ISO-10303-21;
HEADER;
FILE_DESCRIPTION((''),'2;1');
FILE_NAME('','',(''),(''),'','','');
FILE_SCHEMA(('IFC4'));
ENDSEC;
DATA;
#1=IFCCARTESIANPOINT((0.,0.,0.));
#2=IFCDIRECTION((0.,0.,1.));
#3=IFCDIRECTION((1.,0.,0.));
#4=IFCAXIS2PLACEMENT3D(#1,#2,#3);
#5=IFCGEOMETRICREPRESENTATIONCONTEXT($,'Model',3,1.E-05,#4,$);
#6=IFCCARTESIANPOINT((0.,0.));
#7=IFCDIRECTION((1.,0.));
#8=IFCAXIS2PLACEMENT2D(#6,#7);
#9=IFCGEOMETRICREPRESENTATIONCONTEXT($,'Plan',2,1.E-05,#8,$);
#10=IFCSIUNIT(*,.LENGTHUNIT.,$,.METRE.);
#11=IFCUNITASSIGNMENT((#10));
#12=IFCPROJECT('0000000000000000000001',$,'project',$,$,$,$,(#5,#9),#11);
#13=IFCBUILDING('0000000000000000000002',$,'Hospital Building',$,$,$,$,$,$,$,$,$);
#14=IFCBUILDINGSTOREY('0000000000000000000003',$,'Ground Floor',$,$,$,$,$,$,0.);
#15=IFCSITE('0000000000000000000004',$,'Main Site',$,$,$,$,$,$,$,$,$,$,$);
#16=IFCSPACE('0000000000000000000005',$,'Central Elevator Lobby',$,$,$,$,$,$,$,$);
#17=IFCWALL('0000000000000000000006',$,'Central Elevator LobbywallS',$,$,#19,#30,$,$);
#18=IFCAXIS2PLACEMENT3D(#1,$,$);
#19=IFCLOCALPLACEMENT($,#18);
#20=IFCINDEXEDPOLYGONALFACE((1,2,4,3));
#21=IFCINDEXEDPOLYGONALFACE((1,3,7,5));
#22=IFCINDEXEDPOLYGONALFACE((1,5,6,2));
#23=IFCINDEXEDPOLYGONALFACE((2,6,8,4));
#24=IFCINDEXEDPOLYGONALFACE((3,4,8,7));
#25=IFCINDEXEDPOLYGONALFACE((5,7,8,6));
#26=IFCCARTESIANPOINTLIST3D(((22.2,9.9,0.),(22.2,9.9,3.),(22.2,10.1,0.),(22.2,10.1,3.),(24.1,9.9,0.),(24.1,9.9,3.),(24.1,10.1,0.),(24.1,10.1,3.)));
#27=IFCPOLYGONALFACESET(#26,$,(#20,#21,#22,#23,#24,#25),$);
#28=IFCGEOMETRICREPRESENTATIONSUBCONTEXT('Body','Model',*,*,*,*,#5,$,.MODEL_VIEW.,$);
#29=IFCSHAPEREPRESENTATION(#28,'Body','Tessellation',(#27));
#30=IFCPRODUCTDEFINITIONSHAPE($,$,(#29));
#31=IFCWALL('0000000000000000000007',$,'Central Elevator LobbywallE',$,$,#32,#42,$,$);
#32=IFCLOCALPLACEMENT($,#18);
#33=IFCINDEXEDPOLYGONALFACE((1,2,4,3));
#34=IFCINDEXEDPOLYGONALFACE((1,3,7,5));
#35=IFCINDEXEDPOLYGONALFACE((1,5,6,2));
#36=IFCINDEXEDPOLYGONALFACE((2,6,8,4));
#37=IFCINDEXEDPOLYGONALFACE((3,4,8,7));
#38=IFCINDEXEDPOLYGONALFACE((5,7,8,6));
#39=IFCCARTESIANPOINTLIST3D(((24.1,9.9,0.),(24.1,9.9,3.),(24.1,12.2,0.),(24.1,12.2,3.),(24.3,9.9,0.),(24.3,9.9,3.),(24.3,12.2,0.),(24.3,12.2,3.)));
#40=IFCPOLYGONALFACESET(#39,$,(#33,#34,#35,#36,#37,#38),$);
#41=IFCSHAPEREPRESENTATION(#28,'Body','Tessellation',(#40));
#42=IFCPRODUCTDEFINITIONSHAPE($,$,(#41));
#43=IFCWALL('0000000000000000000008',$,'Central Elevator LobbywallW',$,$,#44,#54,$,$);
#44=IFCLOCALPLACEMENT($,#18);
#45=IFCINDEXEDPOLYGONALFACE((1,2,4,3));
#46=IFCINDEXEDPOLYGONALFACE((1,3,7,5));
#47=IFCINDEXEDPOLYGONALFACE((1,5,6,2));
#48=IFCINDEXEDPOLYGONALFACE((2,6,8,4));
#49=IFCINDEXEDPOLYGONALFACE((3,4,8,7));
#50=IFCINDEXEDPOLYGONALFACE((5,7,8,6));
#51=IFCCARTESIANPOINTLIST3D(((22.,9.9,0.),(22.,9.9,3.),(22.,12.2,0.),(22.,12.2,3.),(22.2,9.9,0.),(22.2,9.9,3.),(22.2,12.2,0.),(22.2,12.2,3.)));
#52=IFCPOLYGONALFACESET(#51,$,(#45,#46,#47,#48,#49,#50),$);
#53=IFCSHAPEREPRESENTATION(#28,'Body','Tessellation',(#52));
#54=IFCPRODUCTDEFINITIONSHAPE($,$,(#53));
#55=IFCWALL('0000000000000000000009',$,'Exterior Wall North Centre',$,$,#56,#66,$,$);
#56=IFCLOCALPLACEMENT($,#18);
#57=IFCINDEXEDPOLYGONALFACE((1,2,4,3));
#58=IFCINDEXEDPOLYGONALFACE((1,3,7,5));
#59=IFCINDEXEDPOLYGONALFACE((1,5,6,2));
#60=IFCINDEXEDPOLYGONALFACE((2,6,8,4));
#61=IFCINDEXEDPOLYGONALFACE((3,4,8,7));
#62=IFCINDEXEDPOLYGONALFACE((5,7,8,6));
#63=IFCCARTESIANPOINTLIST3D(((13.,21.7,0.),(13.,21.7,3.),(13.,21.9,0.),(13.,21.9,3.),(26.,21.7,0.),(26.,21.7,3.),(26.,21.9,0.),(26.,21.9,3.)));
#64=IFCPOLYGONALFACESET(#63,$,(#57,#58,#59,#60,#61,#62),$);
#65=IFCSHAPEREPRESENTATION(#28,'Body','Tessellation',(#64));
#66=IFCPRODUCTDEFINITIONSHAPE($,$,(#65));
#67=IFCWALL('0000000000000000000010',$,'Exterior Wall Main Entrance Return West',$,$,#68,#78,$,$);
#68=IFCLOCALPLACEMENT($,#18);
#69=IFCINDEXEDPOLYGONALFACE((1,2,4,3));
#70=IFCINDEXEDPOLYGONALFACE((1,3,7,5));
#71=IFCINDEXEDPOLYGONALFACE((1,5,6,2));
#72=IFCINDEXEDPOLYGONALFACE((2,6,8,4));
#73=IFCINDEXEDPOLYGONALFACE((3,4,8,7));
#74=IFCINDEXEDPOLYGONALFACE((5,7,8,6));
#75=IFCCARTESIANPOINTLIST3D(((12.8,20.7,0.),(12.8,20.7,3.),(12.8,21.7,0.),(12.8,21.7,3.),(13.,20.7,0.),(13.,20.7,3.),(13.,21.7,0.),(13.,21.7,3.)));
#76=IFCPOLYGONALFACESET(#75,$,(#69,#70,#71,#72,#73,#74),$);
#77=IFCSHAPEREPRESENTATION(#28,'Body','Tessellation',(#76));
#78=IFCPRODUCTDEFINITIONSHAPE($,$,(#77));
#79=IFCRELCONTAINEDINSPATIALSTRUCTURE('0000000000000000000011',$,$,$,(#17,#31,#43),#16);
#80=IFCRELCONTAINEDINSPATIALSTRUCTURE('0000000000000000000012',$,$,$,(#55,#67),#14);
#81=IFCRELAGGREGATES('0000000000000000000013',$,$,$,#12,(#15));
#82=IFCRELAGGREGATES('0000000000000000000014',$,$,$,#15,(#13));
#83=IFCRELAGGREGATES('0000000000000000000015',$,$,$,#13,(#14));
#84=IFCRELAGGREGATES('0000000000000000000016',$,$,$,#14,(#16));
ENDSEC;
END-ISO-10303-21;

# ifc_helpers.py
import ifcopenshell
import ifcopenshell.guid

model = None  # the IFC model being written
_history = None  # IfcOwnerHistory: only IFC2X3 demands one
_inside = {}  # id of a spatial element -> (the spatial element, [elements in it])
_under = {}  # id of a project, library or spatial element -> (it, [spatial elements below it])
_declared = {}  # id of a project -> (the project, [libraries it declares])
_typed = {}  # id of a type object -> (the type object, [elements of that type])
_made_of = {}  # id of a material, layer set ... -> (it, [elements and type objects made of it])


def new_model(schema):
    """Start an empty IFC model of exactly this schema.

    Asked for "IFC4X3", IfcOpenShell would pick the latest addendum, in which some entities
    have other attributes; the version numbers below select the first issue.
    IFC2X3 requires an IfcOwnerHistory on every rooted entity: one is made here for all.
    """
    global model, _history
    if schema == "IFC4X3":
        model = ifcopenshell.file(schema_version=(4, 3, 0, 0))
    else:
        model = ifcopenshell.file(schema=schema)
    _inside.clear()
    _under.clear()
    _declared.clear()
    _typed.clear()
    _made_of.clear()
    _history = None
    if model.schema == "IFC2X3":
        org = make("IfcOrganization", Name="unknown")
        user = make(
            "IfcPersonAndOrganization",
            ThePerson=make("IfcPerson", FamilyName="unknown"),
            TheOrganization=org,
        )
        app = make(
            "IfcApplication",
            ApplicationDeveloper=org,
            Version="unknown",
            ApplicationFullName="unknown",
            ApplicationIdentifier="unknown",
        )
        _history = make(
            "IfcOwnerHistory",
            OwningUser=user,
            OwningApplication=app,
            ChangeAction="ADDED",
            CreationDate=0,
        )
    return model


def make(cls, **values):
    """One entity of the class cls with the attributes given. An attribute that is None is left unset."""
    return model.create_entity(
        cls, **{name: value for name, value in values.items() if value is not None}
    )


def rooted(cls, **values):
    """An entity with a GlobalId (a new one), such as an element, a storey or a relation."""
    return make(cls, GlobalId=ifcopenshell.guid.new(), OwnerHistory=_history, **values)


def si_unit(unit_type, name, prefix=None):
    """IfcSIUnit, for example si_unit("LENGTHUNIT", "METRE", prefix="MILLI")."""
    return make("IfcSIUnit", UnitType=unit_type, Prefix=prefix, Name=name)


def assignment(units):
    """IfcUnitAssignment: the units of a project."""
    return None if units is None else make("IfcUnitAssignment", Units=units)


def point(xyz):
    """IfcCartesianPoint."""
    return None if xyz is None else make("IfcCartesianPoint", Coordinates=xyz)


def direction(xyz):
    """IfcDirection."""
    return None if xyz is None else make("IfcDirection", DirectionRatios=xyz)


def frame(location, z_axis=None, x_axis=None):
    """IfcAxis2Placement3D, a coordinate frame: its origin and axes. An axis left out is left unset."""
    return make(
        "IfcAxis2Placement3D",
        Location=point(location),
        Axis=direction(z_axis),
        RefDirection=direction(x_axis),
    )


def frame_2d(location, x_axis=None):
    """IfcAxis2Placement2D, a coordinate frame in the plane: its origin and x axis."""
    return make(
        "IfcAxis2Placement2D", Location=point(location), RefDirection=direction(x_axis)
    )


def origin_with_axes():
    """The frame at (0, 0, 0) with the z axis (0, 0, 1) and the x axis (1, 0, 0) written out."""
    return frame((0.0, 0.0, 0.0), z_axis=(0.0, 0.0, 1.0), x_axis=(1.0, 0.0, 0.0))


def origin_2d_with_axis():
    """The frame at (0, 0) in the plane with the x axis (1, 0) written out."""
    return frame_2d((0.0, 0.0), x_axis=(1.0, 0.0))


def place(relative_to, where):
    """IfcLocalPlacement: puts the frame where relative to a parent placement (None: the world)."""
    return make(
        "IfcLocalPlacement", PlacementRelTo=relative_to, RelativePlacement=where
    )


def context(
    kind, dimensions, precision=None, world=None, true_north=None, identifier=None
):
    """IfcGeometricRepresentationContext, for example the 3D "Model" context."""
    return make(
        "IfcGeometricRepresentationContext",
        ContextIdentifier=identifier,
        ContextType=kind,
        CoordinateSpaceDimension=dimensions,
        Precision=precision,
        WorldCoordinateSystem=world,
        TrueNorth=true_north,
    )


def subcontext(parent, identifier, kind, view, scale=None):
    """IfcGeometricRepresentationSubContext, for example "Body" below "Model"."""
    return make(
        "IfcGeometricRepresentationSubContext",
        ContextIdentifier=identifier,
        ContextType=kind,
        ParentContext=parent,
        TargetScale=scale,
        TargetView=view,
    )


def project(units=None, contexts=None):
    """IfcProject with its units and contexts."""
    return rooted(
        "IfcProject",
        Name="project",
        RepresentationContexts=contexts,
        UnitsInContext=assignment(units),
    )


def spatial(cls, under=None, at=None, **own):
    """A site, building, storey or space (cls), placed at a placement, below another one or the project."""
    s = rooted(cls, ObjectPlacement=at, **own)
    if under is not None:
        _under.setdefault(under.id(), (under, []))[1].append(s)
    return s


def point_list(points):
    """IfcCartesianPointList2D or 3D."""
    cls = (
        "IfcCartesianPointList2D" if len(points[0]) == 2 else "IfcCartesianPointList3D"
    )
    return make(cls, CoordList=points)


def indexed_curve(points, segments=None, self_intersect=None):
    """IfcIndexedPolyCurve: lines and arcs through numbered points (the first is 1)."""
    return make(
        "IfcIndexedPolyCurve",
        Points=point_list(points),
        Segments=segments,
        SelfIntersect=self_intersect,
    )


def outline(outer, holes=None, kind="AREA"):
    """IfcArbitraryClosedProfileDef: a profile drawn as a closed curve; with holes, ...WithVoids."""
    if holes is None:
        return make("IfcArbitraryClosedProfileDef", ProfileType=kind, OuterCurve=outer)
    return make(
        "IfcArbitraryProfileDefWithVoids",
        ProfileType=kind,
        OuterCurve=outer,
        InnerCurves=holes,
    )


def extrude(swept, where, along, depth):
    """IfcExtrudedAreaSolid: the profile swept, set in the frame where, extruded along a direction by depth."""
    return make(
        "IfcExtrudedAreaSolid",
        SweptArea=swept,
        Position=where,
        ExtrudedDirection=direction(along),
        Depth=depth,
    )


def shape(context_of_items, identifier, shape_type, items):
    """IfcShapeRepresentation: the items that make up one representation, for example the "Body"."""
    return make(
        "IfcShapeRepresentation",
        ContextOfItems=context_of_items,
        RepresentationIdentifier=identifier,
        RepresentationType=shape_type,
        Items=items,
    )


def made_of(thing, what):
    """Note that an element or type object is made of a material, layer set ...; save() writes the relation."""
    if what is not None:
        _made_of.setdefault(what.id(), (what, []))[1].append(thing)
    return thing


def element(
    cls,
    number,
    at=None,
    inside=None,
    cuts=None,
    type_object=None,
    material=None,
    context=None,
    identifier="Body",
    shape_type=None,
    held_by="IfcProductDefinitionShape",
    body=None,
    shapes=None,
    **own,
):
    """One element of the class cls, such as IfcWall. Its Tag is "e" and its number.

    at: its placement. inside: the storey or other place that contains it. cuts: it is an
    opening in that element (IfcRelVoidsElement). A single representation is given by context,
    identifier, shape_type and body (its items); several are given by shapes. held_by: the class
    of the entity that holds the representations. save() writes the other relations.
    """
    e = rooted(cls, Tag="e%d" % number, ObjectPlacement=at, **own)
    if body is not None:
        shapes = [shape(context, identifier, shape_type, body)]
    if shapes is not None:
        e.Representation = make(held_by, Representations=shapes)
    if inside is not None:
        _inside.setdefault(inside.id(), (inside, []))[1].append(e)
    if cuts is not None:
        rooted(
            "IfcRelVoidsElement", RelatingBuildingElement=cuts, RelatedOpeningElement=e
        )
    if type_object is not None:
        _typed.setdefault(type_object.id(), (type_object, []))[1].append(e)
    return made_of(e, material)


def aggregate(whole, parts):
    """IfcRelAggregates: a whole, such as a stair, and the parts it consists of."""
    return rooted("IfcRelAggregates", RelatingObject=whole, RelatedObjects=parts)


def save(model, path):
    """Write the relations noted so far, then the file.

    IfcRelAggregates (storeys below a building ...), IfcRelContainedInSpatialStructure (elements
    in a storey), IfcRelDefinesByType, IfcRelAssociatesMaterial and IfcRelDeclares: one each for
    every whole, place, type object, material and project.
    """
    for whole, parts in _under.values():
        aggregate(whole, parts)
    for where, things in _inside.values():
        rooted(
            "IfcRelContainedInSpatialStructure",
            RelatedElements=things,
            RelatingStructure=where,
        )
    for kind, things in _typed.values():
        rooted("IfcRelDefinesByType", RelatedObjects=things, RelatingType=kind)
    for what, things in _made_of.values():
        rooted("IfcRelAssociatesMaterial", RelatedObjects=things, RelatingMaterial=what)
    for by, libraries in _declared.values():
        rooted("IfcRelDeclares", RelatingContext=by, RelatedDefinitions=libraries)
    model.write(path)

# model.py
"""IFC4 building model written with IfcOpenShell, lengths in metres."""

from ifc_helpers import new_model, si_unit, frame, origin_with_axes, origin_2d_with_axis, place, context, subcontext, project, spatial, indexed_curve, outline, extrude, element, save


model = new_model("IFC4")

# Units and contexts
model_context = context("Model", 3, precision=1e-05, world=origin_with_axes())
plan_context = context("Plan", 2, precision=1e-05, world=origin_2d_with_axis())
body_context = subcontext(model_context, "Body", "Model", "MODEL_VIEW")
ifc_project = project(units=[si_unit("LENGTHUNIT", "METRE")], contexts=[model_context, plan_context])

# Site, building, storey
site = spatial("IfcSite", under=ifc_project, Name="Main Site")
building = spatial("IfcBuilding", under=site, Name="Hospital Building")
storey = spatial("IfcBuildingStorey", under=building, Name="Ground Floor", Elevation=0.0)

# Shared definitions
space_1 = spatial("IfcSpace", under=storey, Name="Central Elevator Lobby")

# Walls
for number, where, z_axis, x_axis, name in (
    (1, (22.2, 9.9, 0.0), (0.0, 0.0, 1.0), (1.0, 0.0, 0.0), "Central Elevator LobbywallS"),
):
    element("IfcWall", number, at=place(None, frame(where, z_axis=z_axis, x_axis=x_axis)), inside=space_1, Name=name, context=body_context, shape_type="SweptSolid", body=[
        extrude(outline(indexed_curve([(0.0, 0.0), (0.0, 0.2), (1.9, 0.2), (1.9, 0.0), (0.0, 0.0)], self_intersect=False)), origin_with_axes(), (0.0, 0.0, 1.0), 3.0),
    ])
for number, where, z_axis, x_axis, name in (
    (2, (24.3, 9.9, 0.0), (0.0, 0.0, 1.0), (0.0, 1.0, 0.0), "Central Elevator LobbywallE"),
    (3, (22.2, 9.9, 0.0), (0.0, 0.0, 1.0), (0.0, 1.0, 0.0), "Central Elevator LobbywallW"),
):
    element("IfcWall", number, at=place(None, frame(where, z_axis=z_axis, x_axis=x_axis)), inside=space_1, Name=name, context=body_context, shape_type="SweptSolid", body=[
        extrude(outline(indexed_curve([(0.0, 0.0), (0.0, 0.2), (2.3, 0.2), (2.3, 0.0), (0.0, 0.0)], self_intersect=False)), origin_with_axes(), (0.0, 0.0, 1.0), 3.0),
    ])
wall_1_placement = place(None, frame((13.0, 21.7, 0.0), z_axis=(0.0, 0.0, 1.0), x_axis=(1.0, 0.0, 0.0)))
element("IfcWall", 4, at=wall_1_placement, inside=storey, Name="Exterior Wall North Centre", context=body_context, shape_type="SweptSolid", body=[
    extrude(outline(indexed_curve([(0.0, 0.0), (0.0, 0.2), (13.0, 0.2), (13.0, 0.0), (0.0, 0.0)], self_intersect=False)), origin_with_axes(), (0.0, 0.0, 1.0), 3.0),
])
wall_2_placement = place(None, frame((13.0, 20.7, 0.0), z_axis=(0.0, 0.0, 1.0), x_axis=(0.0, 1.0, 0.0)))
element("IfcWall", 5, at=wall_2_placement, inside=storey, Name="Exterior Wall Main Entrance Return West", context=body_context, shape_type="SweptSolid", body=[
    extrude(outline(indexed_curve([(0.0, 0.0), (0.0, 0.2), (1.0, 0.2), (1.0, 0.0), (0.0, 0.0)], self_intersect=False)), origin_with_axes(), (0.0, 0.0, 1.0), 3.0),
])

save(model, "model.ifc")
